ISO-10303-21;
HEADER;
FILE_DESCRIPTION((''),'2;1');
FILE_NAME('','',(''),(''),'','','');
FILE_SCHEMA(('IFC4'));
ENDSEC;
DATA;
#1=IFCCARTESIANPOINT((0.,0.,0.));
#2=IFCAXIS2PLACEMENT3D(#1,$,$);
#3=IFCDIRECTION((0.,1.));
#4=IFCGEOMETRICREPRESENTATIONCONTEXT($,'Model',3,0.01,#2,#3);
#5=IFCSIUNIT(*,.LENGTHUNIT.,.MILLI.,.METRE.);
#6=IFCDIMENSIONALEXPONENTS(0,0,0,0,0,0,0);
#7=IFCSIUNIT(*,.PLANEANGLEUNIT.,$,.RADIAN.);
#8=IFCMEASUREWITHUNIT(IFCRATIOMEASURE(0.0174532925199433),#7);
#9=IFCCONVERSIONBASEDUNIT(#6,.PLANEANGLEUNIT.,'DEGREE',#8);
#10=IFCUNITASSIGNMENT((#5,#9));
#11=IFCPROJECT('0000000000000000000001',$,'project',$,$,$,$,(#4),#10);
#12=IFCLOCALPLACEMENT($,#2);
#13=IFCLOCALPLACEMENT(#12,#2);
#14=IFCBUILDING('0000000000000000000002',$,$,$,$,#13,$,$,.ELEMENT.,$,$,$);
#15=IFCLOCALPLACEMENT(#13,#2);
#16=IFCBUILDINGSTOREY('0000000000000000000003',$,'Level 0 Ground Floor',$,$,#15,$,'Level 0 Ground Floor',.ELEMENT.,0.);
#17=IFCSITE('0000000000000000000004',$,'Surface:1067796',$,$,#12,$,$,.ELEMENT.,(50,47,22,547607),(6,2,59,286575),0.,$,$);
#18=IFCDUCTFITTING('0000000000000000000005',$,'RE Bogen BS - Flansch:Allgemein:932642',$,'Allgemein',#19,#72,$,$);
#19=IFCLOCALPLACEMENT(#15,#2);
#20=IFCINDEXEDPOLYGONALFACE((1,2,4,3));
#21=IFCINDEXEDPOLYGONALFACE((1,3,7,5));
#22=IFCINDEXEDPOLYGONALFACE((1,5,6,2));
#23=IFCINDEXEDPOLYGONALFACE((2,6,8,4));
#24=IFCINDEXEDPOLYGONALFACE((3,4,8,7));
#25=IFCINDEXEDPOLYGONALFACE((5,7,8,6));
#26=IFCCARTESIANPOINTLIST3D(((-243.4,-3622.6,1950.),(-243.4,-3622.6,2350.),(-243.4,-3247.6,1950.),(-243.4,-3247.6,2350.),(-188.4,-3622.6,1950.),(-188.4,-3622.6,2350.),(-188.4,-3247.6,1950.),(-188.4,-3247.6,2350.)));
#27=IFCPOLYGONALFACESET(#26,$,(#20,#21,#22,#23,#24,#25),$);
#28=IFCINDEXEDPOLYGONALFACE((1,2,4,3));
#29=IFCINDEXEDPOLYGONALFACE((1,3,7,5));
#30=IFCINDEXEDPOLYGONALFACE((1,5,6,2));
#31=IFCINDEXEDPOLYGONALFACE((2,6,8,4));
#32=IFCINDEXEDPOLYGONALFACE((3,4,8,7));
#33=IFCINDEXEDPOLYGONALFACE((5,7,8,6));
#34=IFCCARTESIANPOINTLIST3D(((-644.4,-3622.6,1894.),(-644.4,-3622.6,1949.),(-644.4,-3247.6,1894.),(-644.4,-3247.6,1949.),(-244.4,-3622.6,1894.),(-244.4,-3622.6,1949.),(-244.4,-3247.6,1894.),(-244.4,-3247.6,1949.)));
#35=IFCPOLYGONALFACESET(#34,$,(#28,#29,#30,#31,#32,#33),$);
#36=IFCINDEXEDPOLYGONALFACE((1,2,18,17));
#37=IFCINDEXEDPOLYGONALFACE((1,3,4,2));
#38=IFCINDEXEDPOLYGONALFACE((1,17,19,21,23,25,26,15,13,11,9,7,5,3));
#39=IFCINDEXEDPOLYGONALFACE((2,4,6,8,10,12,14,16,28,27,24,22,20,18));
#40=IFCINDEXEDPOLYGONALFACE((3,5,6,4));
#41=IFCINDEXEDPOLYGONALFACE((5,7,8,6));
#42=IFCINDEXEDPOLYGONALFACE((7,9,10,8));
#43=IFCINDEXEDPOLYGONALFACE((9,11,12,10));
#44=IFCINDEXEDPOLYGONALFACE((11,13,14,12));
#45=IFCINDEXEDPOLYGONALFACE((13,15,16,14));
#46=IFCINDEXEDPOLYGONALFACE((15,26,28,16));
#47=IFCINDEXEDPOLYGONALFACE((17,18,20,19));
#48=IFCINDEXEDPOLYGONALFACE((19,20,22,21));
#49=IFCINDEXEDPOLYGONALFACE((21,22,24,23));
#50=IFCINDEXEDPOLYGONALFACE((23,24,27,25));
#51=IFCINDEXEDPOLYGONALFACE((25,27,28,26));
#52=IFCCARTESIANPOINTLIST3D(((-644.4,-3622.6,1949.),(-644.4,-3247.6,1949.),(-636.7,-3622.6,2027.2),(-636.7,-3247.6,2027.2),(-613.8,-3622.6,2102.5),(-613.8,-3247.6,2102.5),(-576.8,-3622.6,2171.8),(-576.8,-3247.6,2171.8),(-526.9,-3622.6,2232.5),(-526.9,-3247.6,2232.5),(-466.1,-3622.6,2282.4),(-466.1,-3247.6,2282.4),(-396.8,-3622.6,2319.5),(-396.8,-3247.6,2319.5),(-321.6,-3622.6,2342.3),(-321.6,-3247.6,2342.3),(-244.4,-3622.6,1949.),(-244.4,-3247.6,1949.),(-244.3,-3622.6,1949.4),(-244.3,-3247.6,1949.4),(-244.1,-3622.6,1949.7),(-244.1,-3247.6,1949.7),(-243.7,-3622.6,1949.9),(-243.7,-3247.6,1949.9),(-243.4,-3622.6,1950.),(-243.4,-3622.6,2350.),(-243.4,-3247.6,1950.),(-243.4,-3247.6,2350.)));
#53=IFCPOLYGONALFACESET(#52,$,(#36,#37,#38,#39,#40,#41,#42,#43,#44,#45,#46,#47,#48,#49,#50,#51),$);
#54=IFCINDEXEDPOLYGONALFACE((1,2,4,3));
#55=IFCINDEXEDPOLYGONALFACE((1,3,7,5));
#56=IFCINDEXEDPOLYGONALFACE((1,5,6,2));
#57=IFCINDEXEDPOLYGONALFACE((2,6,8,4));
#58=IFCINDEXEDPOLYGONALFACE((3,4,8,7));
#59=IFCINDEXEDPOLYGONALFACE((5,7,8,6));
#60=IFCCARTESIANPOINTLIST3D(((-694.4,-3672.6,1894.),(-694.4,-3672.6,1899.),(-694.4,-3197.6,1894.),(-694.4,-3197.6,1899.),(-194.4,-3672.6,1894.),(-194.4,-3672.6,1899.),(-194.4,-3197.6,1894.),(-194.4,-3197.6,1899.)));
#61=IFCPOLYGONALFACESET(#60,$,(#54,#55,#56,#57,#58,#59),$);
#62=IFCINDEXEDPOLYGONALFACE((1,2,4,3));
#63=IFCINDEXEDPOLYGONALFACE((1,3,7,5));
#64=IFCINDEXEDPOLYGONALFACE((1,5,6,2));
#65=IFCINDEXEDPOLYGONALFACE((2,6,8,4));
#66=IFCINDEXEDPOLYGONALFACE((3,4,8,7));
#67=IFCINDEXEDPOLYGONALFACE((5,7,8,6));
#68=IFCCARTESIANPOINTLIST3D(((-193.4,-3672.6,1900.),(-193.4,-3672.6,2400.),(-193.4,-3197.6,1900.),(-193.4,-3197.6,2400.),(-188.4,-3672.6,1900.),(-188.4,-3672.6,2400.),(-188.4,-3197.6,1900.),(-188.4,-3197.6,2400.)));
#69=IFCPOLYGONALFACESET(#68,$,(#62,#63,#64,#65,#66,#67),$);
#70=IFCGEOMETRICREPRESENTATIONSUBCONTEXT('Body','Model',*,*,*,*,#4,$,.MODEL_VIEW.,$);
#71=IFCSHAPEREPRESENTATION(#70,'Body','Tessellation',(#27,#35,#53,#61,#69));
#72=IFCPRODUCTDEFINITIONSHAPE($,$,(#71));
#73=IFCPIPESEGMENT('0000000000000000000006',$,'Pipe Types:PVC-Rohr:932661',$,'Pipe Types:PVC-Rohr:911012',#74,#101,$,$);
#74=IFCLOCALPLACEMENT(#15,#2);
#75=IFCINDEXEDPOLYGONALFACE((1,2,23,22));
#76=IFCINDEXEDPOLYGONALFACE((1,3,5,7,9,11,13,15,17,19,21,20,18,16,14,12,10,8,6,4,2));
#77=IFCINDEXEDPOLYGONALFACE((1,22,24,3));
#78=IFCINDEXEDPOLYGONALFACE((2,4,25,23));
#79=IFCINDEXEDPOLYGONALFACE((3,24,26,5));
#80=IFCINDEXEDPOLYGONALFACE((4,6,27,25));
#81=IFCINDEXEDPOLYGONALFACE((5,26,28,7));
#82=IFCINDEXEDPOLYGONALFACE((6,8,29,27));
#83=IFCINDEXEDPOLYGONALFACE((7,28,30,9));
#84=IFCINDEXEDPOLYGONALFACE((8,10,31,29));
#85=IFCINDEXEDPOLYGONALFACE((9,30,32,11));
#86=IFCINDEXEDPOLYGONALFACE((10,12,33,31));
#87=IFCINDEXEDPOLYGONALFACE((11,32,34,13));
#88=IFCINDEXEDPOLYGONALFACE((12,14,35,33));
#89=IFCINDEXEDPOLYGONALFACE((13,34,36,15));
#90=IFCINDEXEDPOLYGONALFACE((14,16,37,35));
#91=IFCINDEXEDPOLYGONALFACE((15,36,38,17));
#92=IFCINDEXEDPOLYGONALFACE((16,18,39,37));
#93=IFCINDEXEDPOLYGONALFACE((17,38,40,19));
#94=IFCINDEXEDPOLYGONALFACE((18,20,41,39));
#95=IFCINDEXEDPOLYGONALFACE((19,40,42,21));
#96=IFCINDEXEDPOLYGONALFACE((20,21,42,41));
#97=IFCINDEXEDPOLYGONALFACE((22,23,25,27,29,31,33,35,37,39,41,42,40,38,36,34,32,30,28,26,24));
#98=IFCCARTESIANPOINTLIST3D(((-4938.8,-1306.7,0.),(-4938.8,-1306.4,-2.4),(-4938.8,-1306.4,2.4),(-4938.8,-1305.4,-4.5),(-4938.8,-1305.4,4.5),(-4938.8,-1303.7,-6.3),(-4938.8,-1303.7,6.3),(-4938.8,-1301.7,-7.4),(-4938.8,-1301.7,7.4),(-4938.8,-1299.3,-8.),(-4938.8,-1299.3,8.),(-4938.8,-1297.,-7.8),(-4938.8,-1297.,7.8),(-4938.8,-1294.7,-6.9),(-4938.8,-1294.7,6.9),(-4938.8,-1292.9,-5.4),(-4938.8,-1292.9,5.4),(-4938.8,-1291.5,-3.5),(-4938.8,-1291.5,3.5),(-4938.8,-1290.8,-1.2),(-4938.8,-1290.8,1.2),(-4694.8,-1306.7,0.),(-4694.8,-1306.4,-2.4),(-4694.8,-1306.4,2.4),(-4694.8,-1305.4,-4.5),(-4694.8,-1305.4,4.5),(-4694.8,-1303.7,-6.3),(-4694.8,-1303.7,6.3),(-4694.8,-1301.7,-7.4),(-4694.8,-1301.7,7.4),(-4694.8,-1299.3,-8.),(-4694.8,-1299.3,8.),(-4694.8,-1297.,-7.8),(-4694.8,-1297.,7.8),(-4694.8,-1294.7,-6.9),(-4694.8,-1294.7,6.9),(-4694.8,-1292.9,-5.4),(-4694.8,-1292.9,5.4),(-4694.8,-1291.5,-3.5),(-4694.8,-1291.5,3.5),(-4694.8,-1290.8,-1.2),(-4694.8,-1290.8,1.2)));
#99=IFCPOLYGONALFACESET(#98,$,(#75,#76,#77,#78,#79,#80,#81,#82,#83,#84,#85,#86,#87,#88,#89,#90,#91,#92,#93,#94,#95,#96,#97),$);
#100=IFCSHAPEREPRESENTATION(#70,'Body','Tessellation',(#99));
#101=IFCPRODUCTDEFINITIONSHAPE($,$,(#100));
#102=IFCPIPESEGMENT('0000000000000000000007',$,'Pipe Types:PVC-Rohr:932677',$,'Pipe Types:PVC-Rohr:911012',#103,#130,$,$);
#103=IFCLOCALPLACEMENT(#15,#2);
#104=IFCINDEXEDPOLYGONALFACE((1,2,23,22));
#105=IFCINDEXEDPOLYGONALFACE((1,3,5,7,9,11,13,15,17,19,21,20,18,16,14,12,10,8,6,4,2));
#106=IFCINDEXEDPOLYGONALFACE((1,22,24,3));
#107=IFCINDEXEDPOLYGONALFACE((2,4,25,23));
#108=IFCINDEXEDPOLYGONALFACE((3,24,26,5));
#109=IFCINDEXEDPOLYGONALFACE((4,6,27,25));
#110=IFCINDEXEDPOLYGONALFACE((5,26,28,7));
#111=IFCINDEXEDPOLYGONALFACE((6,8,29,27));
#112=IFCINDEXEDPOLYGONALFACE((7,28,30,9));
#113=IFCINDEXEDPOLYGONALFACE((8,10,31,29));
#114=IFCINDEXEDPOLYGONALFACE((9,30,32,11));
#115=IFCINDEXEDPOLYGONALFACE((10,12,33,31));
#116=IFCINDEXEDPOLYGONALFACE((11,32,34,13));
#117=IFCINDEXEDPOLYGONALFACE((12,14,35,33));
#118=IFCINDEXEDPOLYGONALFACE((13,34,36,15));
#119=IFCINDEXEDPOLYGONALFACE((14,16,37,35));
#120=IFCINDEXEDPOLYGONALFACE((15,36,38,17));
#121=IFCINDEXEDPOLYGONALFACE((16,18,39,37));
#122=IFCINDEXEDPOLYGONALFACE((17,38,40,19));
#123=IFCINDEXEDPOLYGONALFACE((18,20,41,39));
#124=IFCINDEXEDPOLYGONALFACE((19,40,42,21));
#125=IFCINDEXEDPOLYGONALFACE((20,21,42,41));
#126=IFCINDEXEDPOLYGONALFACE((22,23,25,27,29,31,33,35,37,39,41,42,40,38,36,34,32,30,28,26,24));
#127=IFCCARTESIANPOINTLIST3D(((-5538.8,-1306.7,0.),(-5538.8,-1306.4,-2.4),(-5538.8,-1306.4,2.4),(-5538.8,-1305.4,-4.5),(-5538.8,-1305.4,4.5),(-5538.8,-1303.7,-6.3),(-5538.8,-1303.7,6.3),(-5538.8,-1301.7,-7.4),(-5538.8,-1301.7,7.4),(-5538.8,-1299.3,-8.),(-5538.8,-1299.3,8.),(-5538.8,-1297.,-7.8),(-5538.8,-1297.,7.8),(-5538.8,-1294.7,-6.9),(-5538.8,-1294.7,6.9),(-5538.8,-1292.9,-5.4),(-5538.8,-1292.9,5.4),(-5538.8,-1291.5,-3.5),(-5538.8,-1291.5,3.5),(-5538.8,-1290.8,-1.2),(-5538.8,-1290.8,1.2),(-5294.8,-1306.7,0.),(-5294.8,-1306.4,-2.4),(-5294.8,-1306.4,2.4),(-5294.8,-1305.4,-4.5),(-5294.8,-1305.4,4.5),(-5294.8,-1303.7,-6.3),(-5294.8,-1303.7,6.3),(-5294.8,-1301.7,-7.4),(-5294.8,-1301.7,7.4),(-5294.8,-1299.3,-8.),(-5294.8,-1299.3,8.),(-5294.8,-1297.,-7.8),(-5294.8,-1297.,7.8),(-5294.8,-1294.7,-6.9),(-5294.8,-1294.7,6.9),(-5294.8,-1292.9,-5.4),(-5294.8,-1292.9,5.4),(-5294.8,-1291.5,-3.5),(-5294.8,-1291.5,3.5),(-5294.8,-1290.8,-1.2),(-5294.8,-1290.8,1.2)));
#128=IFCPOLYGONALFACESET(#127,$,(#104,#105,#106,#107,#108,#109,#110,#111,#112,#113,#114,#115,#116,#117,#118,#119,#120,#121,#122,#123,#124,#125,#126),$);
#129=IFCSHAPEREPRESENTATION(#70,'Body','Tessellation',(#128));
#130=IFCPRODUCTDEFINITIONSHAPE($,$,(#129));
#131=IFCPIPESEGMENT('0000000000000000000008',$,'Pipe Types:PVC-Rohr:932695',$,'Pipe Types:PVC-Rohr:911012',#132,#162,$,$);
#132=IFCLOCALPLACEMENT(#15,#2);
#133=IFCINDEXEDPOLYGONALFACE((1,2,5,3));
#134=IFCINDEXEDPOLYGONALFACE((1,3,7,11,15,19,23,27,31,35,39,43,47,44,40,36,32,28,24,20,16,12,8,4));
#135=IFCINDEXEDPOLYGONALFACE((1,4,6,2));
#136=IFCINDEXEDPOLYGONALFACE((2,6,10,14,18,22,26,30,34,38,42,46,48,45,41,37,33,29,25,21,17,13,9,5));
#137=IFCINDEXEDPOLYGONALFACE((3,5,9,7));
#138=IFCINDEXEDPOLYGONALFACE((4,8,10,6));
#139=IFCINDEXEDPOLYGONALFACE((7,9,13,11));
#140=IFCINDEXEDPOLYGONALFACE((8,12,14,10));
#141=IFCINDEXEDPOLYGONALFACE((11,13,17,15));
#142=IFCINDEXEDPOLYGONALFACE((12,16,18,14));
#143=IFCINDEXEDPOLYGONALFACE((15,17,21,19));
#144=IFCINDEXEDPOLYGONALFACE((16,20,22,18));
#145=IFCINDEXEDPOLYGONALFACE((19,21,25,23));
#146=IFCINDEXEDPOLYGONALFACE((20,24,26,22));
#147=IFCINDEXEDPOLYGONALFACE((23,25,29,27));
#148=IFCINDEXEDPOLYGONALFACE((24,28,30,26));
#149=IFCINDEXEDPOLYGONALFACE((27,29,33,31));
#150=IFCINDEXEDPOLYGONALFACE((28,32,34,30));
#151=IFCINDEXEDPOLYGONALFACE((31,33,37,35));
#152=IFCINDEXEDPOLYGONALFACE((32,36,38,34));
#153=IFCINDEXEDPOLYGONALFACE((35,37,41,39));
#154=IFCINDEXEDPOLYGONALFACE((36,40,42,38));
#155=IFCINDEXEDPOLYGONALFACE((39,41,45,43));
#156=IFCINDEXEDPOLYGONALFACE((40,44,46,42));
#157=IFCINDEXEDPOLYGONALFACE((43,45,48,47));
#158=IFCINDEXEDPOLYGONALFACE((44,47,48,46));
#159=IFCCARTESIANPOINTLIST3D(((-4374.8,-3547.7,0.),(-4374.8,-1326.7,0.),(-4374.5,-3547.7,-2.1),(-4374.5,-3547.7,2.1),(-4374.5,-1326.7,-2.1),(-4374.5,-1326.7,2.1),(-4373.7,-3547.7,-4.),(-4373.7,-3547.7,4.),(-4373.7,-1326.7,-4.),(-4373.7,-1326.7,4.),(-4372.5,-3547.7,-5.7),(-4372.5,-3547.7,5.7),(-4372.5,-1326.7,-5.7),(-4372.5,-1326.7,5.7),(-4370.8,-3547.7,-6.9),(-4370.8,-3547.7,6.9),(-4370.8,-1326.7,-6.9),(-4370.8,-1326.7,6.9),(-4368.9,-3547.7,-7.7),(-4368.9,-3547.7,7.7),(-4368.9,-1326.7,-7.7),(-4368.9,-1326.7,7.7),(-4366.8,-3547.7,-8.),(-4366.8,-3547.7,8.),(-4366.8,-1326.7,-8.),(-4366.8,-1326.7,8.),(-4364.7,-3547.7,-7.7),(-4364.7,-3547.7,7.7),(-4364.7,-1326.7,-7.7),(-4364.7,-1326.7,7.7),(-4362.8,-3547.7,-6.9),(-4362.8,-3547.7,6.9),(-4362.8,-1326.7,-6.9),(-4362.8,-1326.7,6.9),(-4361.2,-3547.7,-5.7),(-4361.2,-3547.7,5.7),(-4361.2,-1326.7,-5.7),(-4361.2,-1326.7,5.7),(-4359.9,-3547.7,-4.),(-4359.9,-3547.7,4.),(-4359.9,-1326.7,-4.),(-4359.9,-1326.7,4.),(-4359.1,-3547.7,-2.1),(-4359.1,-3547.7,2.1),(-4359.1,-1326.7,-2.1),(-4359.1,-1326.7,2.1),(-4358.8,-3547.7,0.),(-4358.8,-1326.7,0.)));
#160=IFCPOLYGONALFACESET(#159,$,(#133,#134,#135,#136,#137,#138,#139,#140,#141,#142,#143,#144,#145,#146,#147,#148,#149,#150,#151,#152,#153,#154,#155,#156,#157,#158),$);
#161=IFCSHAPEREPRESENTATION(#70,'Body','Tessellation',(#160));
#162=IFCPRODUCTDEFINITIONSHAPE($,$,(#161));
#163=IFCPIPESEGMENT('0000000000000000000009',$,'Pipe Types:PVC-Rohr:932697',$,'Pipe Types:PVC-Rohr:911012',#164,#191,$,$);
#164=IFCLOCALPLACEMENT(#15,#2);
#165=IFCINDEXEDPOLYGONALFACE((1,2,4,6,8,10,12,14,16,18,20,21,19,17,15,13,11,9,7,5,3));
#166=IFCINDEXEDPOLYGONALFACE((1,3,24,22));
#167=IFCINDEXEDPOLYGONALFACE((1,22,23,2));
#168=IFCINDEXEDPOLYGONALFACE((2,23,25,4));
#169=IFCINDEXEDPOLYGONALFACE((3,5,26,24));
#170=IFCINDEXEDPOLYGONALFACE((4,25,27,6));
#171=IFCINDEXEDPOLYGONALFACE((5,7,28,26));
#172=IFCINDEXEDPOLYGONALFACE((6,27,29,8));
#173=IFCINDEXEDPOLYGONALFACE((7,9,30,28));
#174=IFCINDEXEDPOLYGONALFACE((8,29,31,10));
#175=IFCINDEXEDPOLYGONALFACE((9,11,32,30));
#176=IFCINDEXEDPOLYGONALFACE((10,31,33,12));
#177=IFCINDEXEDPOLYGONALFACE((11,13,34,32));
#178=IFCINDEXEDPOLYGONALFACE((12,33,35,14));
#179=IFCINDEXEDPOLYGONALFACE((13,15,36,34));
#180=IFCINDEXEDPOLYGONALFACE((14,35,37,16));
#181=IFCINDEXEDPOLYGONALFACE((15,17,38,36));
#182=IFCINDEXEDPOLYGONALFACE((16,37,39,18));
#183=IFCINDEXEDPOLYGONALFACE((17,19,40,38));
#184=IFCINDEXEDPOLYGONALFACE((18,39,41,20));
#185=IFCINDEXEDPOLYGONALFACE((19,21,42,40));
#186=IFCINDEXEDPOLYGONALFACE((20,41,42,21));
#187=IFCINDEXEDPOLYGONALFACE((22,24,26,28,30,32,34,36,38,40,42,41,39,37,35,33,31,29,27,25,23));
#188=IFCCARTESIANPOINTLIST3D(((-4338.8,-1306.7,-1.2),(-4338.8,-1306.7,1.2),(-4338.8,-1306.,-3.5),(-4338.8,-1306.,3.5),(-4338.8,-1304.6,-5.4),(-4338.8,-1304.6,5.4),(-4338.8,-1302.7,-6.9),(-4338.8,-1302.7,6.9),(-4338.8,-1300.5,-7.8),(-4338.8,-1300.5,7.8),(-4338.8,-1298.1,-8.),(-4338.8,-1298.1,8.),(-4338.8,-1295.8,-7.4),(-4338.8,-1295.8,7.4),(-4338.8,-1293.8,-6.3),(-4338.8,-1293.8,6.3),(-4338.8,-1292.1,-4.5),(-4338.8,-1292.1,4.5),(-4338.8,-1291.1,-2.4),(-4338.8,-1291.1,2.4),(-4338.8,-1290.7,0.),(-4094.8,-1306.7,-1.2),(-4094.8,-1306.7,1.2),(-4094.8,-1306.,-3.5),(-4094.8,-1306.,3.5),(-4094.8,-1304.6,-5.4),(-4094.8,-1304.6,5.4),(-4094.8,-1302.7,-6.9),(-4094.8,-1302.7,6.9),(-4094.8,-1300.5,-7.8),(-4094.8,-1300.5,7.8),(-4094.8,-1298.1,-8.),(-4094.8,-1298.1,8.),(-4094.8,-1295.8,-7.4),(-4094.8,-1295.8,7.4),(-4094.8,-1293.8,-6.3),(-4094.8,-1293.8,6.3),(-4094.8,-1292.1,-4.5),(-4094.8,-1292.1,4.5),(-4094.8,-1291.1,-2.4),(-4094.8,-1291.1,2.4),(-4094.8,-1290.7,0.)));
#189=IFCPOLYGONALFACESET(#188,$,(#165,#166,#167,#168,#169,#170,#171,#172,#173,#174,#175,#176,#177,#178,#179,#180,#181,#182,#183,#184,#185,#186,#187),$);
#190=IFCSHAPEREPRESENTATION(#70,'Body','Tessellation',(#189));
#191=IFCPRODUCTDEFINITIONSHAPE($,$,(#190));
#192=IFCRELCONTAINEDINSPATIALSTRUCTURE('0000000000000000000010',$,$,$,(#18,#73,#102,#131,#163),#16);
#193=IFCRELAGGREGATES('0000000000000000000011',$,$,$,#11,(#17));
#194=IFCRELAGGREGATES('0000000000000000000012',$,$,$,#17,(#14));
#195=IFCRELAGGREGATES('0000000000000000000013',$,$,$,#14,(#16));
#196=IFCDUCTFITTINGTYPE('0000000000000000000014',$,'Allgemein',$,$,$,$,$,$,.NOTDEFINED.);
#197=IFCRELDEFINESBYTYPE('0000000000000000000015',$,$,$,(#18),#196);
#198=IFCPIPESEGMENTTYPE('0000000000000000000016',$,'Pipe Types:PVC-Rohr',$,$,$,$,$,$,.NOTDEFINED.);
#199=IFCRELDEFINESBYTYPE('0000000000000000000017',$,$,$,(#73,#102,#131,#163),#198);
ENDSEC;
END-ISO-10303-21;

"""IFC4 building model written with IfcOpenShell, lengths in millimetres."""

from ifc_helpers import new_model, entity, si_unit, converted_unit, direction, frame, frame_2d, origin, origin_2d_with_axis, place, context, subcontext, project, spatial, polyline, circle_curve, parameter, trimmed, segment, composite_curve, rectangle, circle, outline, extrude, source, transform, mapped, type_object, type_shapes, element, save


model = new_model("IFC4")

# Units and contexts
model_context = context("Model", 3, precision=0.01, world=origin(), true_north=direction((0.0, 1.0)))
body_context = subcontext(model_context, "Body", "Model", "MODEL_VIEW")
ifc_project = project(units=[si_unit("LENGTHUNIT", "METRE", prefix="MILLI"), converted_unit("PLANEANGLEUNIT", "DEGREE", entity("IfcRatioMeasure", 0.0174532925199433), si_unit("PLANEANGLEUNIT", "RADIAN"), dimensions=[0, 0, 0, 0, 0, 0, 0])], contexts=[model_context])

# Site, building, storey
site_placement = place(None, origin())
site = spatial("IfcSite", under=ifc_project, at=site_placement, Name="Surface:1067796", CompositionType="ELEMENT", RefLatitude=(50, 47, 22, 547607), RefLongitude=(6, 2, 59, 286575), RefElevation=0.0)
building_placement = place(site_placement, origin())
building = spatial("IfcBuilding", under=site, at=building_placement, CompositionType="ELEMENT")
storey_placement = place(building_placement, origin())
storey = spatial("IfcBuildingStorey", under=building, at=storey_placement, Name="Level 0 Ground Floor", LongName="Level 0 Ground Floor", CompositionType="ELEMENT", Elevation=0.0)

# Duct fitting
duct_fitting_type = type_object("IfcDuctFittingType", Name="Allgemein", PredefinedType="NOTDEFINED")
shared_shape_1 = source(origin(), body_context, "Body", "SweptSolid", [
    extrude(rectangle(XDim=55.0, YDim=400.0, at=frame_2d((0.0, 0.0), x_axis=(1.0, 0.0))), frame((0.0, 228.5, -187.5), z_axis=(0.0, 0.0, 1.0), x_axis=(0.0, 1.0, 0.0)), (0.0, 0.0, 1.0), 375.0),
    extrude(rectangle(XDim=400.0, YDim=55.0, at=frame_2d((0.0, 0.0), x_axis=(1.0, 0.0))), frame((-228.5, 0.0, -187.5), z_axis=(0.0, 0.0, 1.0), x_axis=(0.0, -1.0, 0.0)), (0.0, 0.0, 1.0), 375.0),
    extrude(outline(composite_curve([segment(polyline([(-300.5, -100.5), (99.5, -100.5)]), True, "CONTINUOUS"), segment(trimmed(circle_curve(frame_2d((100.5, -100.5), x_axis=(0.0, 1.0)), 1.0), [parameter(0.0)], [parameter(90.0)], True, "PARAMETER"), False, "CONTINUOUS"), segment(polyline([(100.5, -99.5), (100.5, 300.5)]), True, "CONTINUOUS"), segment(trimmed(circle_curve(frame_2d((100.5, -100.5), x_axis=(0.0, 1.0)), 401.0), [parameter(0.0)], [parameter(90.0)], True, "PARAMETER"), True, "CONTINUOUS")], self_intersect=False)), frame((-100.5, 100.5, -187.5), z_axis=(0.0, 0.0, 1.0), x_axis=(-1.0, 0.0, 0.0)), (0.0, 0.0, 1.0), 375.0),
    extrude(rectangle(XDim=5.0, YDim=500.0, at=frame_2d((0.0, 0.0), x_axis=(1.0, 0.0))), frame((-253.5, 0.0, -237.5)), (0.0, 0.0, 1.0), 475.0),
    extrude(rectangle(XDim=5.0, YDim=500.0, at=origin_2d_with_axis()), frame((0.0, 253.5, -237.5), z_axis=(0.0, 0.0, 1.0), x_axis=(0.0, 1.0, 0.0)), (0.0, 0.0, 1.0), 475.0),
])
type_shapes(duct_fitting_type, [shared_shape_1])
duct_fitting_placement = place(storey_placement, frame((-444.4, -3435.1, 2150.0), z_axis=(0.0, 1.0, 0.0), x_axis=(0.0, 0.0, 1.0)))
element("IfcDuctFitting", 1, at=duct_fitting_placement, inside=storey, type_object=duct_fitting_type, Name="RE Bogen BS - Flansch:Allgemein:932642", ObjectType="Allgemein", context=body_context, shape_type="MappedRepresentation", body=[
    mapped(shared_shape_1, transform((0.0, 0.0, 0.0), scale=1.0)),
])

# Pipe segments
pipe_segment_type_1 = type_object("IfcPipeSegmentType", Name="Pipe Types:PVC-Rohr", PredefinedType="NOTDEFINED")
pipe_segment_1_placement = place(storey_placement, frame((-4938.8, -1308.3, -9.6)))
element("IfcPipeSegment", 2, at=pipe_segment_1_placement, inside=storey, type_object=pipe_segment_type_1, Name="Pipe Types:PVC-Rohr:932661", ObjectType="Pipe Types:PVC-Rohr:911012", context=body_context, shape_type="SweptSolid", body=[
    extrude(circle(Radius=8.0, at=frame_2d((0.0, 0.0), x_axis=(1.0, 0.0))), frame((0.0, 9.6, 9.6), z_axis=(1.0, 0.0, 0.0), x_axis=(0.0, -1.0, 0.0)), (0.0, 0.0, 1.0), 244.0),
])
pipe_segment_2_placement = place(storey_placement, frame((-5538.8, -1308.3, -9.6)))
element("IfcPipeSegment", 3, at=pipe_segment_2_placement, inside=storey, type_object=pipe_segment_type_1, Name="Pipe Types:PVC-Rohr:932677", ObjectType="Pipe Types:PVC-Rohr:911012", context=body_context, shape_type="SweptSolid", body=[
    extrude(circle(Radius=8.0, at=frame_2d((0.0, 0.0), x_axis=(1.0, 0.0))), frame((0.0, 9.6, 9.6), z_axis=(1.0, 0.0, 0.0), x_axis=(0.0, -1.0, 0.0)), (0.0, 0.0, 1.0), 244.0),
])
pipe_segment_3_placement = place(storey_placement, frame((-4376.4, -3547.7, -9.6)))
element("IfcPipeSegment", 4, at=pipe_segment_3_placement, inside=storey, type_object=pipe_segment_type_1, Name="Pipe Types:PVC-Rohr:932695", ObjectType="Pipe Types:PVC-Rohr:911012", context=body_context, shape_type="SweptSolid", body=[
    extrude(outline(polyline([(-1.0, -7.9), (1.0, -7.9), (3.1, -7.4), (4.9, -6.3), (6.3, -4.9), (7.4, -3.1), (7.9, -1.0), (7.9, 1.0), (7.4, 3.1), (6.3, 4.9), (4.9, 6.3), (3.1, 7.4), (1.0, 7.9), (-1.0, 7.9), (-3.1, 7.4), (-4.9, 6.3), (-6.3, 4.9), (-7.4, 3.1), (-7.9, 1.0), (-7.9, -1.0), (-7.4, -3.1), (-6.3, -4.9), (-4.9, -6.3), (-3.1, -7.4), (-1.0, -7.9)])), frame((9.6, 0.0, 9.6), z_axis=(0.0, 1.0, 0.0), x_axis=(0.130526, 0.0, 0.991445)), (0.0, 0.0, 1.0), 2221.0),
])
pipe_segment_4_placement = place(storey_placement, frame((-4338.8, -1308.3, -9.6)))
element("IfcPipeSegment", 5, at=pipe_segment_4_placement, inside=storey, type_object=pipe_segment_type_1, Name="Pipe Types:PVC-Rohr:932697", ObjectType="Pipe Types:PVC-Rohr:911012", context=body_context, shape_type="SweptSolid", body=[
    extrude(circle(Radius=8.0, at=frame_2d((0.0, 0.0), x_axis=(1.0, 0.0))), frame((0.0, 9.6, 9.6), z_axis=(1.0, 0.0, 0.0), x_axis=(0.0, 1.0, 0.0)), (0.0, 0.0, 1.0), 244.0),
])

save(model, "model.ifc")
